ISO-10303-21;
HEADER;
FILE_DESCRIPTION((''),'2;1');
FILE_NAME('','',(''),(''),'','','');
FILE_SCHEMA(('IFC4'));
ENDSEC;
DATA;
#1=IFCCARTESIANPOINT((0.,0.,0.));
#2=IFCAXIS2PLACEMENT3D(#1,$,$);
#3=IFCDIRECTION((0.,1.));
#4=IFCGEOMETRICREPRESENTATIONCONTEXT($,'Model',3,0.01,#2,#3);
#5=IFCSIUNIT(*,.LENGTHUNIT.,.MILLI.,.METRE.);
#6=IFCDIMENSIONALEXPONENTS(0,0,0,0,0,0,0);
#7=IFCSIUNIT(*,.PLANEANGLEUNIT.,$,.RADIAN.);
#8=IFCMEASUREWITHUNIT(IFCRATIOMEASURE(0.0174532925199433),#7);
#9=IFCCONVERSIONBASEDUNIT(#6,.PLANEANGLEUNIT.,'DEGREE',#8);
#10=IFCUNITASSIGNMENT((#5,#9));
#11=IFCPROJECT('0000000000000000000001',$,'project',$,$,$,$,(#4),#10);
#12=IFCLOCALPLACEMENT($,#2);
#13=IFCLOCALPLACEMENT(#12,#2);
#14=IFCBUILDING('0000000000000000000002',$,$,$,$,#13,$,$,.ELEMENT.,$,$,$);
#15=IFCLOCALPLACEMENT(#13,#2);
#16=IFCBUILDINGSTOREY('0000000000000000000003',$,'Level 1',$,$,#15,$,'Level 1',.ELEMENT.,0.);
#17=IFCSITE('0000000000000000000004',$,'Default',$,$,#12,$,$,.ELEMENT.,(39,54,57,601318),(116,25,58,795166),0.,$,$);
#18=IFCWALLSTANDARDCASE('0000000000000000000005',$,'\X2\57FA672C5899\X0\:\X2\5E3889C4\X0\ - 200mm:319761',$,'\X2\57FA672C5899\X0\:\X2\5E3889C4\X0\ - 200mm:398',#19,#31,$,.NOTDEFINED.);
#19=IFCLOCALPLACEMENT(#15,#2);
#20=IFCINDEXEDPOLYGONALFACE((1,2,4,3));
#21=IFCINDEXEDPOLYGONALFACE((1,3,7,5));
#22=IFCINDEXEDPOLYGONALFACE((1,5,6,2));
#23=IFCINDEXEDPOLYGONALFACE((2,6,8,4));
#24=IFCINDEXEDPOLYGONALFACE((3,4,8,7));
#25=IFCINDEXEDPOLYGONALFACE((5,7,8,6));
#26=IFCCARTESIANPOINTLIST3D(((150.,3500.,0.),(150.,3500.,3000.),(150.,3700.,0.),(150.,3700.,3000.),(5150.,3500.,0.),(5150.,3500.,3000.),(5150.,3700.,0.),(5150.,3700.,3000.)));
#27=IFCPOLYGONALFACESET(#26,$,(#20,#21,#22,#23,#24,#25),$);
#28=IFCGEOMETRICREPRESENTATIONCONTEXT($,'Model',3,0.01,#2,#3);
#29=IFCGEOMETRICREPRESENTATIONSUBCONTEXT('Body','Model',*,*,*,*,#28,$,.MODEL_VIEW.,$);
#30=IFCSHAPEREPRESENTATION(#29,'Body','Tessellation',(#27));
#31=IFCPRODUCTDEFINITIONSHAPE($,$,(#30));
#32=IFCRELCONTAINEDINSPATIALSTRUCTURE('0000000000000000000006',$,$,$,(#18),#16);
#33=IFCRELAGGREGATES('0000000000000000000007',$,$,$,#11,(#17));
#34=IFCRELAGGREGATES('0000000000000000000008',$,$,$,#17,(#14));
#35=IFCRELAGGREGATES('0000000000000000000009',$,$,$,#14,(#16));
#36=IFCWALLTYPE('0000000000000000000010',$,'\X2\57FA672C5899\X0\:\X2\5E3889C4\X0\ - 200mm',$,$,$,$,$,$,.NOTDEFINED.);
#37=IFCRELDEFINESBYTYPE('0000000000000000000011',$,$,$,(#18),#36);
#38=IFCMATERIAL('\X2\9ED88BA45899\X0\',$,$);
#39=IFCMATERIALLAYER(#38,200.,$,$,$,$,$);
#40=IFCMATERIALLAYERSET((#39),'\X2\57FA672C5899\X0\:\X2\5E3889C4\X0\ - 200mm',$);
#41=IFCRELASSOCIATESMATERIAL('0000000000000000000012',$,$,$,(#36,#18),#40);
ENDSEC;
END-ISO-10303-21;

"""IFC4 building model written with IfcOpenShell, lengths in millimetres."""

from ifc_helpers import new_model, entity, si_unit, converted_unit, direction, frame, frame_2d, origin, place, context, subcontext, project, spatial, rectangle, extrude, material, layer, layer_set, layer_usage, type_object, element, save


model = new_model("IFC4")

# Units and contexts
model_context_1 = context("Model", 3, precision=0.01, world=origin(), true_north=direction((0.0, 1.0)))
model_context_2 = context("Model", 3, precision=0.01, world=origin(), true_north=direction((0.0, 1.0)))
body_context = subcontext(model_context_2, "Body", "Model", "MODEL_VIEW")
ifc_project = project(units=[si_unit("LENGTHUNIT", "METRE", prefix="MILLI"), converted_unit("PLANEANGLEUNIT", "DEGREE", entity("IfcRatioMeasure", 0.0174532925199433), si_unit("PLANEANGLEUNIT", "RADIAN"), dimensions=[0, 0, 0, 0, 0, 0, 0])], contexts=[model_context_1])

# Site, building, storey
site_placement = place(None, origin())
site = spatial("IfcSite", under=ifc_project, at=site_placement, Name="Default", CompositionType="ELEMENT", RefLatitude=(39, 54, 57, 601318), RefLongitude=(116, 25, 58, 795166), RefElevation=0.0)
building_placement = place(site_placement, origin())
building = spatial("IfcBuilding", under=site, at=building_placement, CompositionType="ELEMENT")
storey_placement = place(building_placement, origin())
storey = spatial("IfcBuildingStorey", under=building, at=storey_placement, Name="Level 1", LongName="Level 1", CompositionType="ELEMENT", Elevation=0.0)

# Shared definitions
ifc_material_1 = material(Name="默认墙")
ifc_layer = layer(ifc_material_1, 200.0)
ifc_layer_set = layer_set([ifc_layer], Name="基本墙:常规 - 200mm")
wall_type = type_object("IfcWallType", Name="基本墙:常规 - 200mm", PredefinedType="NOTDEFINED", material=ifc_layer_set)

# Wall
ifc_layer_usage_1 = layer_usage(ifc_layer_set, "AXIS2", "NEGATIVE", 100.0)
wall_1_placement = place(storey_placement, frame((150.0, 3600.0, 0.0)))
element("IfcWallStandardCase", 1, at=wall_1_placement, inside=storey, type_object=wall_type, material=ifc_layer_usage_1, Name="基本墙:常规 - 200mm:319761", ObjectType="基本墙:常规 - 200mm:398", PredefinedType="NOTDEFINED", context=body_context, shape_type="SweptSolid", body=[
    extrude(rectangle(XDim=5000.0, YDim=200.0, at=frame_2d((2500.0, 0.0), x_axis=(-1.0, 0.0))), origin(), (0.0, 0.0, 1.0), 3000.0),
])

save(model, "model.ifc")
